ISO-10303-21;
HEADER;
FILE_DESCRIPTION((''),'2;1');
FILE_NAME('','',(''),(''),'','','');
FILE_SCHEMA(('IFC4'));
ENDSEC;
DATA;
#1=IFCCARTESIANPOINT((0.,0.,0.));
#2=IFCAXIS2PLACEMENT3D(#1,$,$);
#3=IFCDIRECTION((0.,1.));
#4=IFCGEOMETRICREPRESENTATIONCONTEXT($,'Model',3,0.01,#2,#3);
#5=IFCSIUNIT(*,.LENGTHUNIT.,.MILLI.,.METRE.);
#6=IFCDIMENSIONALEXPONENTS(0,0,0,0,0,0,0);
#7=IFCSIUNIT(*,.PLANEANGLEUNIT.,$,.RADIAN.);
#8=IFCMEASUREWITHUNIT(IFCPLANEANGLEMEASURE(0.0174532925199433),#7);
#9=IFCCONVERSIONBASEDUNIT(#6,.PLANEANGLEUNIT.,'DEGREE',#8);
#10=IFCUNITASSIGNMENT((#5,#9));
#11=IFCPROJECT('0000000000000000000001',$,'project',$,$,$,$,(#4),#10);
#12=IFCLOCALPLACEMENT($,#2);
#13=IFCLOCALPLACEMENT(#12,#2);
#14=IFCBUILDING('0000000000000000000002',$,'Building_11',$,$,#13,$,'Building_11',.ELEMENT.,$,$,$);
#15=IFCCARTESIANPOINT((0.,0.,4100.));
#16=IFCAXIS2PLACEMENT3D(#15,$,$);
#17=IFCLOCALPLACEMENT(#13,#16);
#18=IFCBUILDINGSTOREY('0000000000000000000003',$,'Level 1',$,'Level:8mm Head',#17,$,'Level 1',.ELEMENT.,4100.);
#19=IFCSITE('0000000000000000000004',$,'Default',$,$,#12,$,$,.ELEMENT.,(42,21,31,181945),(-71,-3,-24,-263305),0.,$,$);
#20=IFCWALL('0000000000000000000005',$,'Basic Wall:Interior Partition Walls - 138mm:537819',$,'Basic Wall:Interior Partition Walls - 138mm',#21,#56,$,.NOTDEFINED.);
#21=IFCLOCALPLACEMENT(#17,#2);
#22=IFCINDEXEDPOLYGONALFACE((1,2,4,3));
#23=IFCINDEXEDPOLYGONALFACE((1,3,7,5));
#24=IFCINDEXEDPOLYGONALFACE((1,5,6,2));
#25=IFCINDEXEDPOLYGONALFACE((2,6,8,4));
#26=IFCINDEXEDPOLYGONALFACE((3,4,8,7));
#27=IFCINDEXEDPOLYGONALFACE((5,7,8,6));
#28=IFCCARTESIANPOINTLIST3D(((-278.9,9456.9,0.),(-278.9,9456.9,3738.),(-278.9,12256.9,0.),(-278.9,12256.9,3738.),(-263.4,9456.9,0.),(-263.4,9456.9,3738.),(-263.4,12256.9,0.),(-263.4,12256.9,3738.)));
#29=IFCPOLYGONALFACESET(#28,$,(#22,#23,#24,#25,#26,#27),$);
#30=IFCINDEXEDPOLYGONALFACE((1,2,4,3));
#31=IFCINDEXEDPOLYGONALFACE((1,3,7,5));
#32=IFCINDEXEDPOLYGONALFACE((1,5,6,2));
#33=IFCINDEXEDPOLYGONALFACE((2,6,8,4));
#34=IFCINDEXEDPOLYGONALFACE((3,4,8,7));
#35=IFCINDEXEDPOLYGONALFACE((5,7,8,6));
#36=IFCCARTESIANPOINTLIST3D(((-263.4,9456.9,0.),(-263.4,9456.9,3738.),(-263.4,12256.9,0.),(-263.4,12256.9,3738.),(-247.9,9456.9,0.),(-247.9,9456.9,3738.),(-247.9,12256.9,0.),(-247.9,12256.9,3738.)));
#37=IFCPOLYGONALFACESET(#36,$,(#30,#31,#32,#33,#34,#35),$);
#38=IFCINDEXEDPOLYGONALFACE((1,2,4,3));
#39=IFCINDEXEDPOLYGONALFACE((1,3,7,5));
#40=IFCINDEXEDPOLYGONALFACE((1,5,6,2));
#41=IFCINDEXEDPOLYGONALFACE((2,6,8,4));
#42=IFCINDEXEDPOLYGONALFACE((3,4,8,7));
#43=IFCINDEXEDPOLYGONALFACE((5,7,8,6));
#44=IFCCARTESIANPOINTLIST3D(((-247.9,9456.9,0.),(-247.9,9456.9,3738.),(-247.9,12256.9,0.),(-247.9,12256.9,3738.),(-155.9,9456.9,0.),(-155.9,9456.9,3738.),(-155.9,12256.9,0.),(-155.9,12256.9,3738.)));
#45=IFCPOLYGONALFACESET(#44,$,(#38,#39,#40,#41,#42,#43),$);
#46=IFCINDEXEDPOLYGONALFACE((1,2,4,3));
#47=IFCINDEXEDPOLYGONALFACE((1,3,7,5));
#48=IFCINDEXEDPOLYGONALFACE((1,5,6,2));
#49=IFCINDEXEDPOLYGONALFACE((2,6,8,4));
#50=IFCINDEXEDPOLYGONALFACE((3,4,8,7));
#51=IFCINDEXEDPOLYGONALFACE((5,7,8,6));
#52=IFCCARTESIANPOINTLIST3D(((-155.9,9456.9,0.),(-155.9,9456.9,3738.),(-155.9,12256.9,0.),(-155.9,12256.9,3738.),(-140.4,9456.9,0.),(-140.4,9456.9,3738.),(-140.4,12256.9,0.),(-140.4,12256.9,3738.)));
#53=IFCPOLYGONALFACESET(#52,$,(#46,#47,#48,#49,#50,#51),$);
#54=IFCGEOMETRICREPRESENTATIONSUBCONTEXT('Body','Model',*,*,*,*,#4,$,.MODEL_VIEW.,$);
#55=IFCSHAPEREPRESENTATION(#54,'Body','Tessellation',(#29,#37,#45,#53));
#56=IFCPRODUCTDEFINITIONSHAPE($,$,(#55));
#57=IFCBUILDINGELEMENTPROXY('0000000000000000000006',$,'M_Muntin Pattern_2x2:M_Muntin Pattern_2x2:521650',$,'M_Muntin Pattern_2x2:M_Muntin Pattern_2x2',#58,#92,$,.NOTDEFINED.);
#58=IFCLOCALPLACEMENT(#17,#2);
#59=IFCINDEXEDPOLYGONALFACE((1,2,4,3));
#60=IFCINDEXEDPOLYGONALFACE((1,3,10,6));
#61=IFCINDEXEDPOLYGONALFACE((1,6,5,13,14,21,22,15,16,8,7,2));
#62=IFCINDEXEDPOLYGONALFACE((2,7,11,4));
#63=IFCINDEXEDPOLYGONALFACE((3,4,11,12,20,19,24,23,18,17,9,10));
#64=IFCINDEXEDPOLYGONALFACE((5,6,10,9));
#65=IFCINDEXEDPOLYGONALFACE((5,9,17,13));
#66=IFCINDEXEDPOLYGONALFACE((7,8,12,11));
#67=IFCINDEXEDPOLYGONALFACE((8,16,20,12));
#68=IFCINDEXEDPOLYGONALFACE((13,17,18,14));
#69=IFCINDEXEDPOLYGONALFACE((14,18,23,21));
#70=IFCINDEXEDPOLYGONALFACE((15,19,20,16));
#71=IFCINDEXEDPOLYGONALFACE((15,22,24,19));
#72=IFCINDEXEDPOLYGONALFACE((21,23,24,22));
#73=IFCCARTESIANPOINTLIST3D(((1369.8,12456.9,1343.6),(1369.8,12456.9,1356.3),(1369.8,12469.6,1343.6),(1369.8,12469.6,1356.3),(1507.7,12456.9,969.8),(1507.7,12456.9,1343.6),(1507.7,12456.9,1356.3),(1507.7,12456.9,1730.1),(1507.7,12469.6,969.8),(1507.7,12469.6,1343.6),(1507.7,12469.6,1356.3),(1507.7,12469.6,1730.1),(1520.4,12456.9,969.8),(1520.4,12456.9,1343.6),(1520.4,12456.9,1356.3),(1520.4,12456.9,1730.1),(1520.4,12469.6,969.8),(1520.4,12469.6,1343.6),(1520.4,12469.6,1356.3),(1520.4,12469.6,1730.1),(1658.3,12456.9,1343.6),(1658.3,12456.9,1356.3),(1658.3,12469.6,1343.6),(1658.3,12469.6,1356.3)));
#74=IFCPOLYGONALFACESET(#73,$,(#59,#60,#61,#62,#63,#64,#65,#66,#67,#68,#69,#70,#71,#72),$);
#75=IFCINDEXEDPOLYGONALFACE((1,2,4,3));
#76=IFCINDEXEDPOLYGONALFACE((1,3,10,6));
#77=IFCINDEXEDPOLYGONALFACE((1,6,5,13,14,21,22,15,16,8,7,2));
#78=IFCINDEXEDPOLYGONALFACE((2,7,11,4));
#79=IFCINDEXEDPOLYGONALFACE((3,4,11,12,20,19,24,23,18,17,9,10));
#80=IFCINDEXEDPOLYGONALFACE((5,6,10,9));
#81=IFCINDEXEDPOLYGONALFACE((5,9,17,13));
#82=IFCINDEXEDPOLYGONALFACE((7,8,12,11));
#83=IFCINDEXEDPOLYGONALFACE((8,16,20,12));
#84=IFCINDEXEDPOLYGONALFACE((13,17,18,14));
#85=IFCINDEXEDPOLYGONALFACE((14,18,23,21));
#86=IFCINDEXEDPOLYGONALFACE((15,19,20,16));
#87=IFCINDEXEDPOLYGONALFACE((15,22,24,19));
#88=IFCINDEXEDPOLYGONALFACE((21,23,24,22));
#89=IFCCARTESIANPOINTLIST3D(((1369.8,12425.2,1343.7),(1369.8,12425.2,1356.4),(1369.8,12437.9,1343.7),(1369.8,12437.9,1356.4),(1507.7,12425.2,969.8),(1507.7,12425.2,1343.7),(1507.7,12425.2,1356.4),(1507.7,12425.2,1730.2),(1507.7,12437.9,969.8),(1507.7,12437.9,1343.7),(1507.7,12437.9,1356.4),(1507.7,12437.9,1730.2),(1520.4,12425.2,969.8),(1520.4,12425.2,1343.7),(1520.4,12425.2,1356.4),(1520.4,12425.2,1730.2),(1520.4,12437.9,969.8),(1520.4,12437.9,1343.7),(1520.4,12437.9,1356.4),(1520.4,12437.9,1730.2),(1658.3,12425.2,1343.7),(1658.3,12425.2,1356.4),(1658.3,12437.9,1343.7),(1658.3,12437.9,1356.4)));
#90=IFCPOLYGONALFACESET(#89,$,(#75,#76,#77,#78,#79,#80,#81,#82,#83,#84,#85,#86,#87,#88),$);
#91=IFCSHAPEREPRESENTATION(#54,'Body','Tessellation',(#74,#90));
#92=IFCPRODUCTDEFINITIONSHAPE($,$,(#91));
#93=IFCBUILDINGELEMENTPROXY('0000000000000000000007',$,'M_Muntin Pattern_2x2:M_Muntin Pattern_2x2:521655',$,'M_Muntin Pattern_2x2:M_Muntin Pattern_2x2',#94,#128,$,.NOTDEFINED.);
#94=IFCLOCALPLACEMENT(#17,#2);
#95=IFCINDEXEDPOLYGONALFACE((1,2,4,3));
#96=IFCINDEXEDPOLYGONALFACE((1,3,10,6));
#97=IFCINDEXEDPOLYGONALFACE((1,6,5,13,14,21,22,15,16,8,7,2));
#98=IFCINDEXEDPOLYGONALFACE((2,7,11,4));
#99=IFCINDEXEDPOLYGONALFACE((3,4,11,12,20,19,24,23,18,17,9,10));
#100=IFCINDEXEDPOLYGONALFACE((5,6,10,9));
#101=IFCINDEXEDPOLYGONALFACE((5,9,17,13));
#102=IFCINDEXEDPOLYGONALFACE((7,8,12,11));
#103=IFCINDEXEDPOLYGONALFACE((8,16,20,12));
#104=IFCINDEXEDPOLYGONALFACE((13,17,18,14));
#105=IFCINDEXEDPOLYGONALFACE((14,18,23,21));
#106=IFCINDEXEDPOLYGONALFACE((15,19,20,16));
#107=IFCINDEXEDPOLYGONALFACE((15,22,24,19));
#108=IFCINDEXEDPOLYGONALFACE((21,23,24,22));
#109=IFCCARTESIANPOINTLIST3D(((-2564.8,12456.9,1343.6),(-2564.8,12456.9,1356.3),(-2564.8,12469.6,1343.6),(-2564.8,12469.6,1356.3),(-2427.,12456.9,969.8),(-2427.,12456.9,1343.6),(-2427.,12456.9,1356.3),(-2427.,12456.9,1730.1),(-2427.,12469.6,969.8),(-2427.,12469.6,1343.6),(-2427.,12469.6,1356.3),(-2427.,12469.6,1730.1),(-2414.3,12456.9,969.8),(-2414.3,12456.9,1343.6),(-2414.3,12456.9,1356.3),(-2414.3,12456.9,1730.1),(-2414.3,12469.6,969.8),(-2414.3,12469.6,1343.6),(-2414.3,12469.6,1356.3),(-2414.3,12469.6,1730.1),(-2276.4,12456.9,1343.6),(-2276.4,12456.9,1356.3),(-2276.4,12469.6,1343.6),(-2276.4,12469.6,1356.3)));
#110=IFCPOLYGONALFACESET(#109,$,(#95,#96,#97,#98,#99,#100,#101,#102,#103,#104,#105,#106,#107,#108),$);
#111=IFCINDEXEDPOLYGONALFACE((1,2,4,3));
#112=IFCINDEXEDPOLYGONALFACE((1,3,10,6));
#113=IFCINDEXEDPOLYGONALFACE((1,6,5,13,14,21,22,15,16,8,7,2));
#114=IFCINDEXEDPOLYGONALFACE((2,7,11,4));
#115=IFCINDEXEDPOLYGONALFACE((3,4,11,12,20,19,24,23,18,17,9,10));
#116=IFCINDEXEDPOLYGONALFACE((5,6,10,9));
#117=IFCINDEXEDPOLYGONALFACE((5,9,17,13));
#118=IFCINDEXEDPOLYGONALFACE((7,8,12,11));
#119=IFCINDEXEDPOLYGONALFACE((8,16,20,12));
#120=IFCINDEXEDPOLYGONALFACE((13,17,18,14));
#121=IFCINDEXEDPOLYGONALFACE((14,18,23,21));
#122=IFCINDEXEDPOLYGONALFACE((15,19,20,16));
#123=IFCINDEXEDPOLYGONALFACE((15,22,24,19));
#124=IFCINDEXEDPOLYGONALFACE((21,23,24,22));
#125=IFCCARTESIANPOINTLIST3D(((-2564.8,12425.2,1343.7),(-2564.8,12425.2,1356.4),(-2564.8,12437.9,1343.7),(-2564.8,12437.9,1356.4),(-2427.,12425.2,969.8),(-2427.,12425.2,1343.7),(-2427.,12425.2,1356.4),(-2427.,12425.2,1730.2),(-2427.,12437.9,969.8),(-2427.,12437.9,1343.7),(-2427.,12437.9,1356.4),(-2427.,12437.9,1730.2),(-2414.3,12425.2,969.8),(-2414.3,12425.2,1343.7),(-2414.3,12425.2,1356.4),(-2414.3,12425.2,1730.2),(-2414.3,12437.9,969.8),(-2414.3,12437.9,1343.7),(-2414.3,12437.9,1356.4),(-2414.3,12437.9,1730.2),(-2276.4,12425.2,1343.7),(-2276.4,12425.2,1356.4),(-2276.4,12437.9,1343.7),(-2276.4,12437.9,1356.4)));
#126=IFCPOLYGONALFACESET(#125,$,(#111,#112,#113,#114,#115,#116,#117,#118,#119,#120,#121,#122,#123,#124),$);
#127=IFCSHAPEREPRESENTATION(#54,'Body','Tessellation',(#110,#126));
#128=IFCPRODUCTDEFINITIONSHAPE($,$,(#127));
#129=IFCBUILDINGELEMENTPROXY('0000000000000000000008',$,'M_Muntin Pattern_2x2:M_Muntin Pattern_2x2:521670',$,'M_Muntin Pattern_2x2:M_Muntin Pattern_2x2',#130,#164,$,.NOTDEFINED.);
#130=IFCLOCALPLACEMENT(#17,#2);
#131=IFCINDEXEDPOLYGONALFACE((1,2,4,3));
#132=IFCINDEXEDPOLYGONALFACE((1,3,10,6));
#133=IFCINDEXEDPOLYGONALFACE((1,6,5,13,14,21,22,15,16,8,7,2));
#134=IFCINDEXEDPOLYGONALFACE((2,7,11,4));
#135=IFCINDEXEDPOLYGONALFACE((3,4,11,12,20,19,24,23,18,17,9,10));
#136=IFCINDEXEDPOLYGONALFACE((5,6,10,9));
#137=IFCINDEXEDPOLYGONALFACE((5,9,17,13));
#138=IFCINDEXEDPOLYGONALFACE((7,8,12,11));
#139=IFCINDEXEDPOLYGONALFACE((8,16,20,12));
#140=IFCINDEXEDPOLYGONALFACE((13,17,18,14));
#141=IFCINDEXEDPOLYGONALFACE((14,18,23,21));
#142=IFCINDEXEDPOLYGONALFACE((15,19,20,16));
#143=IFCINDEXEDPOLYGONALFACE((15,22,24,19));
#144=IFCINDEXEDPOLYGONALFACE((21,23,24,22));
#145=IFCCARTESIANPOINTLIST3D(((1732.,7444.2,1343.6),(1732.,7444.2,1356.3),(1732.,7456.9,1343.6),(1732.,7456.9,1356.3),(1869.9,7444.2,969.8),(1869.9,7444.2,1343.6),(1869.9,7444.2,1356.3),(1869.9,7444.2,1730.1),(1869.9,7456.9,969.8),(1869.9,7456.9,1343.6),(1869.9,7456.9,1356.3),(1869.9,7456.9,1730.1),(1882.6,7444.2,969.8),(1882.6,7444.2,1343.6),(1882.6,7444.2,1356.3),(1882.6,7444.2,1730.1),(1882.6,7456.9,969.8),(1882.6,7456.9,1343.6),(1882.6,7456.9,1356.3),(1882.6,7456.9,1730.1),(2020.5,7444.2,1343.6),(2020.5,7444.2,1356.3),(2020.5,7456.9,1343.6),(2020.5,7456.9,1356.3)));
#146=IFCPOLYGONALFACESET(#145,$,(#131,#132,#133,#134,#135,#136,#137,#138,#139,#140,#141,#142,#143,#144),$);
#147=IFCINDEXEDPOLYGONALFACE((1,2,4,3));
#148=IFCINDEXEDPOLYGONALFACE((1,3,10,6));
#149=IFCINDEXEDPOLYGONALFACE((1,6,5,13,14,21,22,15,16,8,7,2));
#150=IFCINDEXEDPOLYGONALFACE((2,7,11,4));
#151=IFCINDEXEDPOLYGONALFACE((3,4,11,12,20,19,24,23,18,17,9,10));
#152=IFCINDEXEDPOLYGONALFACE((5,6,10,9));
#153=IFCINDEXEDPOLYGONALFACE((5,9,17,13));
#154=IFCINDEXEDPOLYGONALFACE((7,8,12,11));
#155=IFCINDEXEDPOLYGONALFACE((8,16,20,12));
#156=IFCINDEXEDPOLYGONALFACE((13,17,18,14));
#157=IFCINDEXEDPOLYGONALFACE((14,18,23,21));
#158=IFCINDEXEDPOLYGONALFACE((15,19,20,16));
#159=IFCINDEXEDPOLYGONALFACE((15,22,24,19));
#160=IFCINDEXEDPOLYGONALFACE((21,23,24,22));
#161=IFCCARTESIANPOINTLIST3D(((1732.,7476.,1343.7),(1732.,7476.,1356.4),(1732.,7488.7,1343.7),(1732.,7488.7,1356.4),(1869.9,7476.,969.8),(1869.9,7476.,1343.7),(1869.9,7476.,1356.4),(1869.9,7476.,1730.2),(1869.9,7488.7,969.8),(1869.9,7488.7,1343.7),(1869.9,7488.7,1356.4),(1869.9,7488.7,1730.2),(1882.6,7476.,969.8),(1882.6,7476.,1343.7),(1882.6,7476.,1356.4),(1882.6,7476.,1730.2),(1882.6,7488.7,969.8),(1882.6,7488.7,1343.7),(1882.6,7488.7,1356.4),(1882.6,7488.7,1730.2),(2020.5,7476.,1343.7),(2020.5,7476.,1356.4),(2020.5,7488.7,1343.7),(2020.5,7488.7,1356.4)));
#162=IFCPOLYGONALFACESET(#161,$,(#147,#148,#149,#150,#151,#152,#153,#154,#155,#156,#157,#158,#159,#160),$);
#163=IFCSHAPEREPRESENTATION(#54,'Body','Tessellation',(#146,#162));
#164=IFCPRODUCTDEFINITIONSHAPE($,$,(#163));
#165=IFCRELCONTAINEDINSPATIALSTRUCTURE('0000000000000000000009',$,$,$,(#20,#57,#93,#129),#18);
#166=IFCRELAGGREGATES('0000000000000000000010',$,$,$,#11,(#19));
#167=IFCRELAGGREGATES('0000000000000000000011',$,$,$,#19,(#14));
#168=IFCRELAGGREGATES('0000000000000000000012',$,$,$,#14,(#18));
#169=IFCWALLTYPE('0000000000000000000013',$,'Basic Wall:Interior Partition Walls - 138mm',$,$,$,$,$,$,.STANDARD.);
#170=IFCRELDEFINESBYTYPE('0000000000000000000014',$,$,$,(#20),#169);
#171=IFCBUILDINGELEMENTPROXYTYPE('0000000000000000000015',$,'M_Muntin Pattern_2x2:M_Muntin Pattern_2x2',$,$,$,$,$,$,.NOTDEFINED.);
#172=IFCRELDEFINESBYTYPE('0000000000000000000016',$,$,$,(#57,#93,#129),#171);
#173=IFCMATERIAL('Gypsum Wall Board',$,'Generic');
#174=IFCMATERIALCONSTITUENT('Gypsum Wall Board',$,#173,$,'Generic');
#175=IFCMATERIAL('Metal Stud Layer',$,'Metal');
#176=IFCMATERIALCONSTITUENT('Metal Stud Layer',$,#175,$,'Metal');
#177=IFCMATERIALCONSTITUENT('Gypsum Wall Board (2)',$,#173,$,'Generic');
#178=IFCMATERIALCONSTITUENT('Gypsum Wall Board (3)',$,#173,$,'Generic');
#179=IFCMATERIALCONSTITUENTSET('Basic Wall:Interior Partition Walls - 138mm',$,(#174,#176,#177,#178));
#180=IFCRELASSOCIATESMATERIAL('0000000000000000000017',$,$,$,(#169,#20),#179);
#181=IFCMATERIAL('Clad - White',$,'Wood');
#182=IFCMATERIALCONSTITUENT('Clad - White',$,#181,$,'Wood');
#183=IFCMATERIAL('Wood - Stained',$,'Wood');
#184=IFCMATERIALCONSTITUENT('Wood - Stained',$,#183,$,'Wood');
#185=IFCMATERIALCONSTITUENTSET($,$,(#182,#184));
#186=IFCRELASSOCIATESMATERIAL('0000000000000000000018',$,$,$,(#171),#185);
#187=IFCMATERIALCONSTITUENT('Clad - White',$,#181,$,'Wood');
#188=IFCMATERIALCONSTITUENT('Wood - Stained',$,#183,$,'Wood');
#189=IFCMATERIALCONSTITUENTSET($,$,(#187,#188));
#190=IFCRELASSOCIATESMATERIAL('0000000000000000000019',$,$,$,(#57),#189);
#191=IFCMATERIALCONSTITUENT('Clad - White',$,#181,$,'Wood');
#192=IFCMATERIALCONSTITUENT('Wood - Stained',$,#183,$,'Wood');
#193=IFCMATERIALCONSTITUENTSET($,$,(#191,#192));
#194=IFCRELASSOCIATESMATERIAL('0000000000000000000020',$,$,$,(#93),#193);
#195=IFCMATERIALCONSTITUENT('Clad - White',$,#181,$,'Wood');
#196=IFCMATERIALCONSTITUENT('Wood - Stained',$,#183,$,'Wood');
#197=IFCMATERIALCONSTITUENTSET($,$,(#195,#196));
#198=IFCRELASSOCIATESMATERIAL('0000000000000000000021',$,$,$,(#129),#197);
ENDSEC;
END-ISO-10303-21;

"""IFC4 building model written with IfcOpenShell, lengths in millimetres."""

from ifc_helpers import new_model, entity, si_unit, converted_unit, direction, frame, origin, place, context, subcontext, project, spatial, indexed_curve, outline, extrude, source, transform, mapped, material, constituent, constituent_set, type_object, type_shapes, element, save


model = new_model("IFC4")

# Units and contexts
model_context = context("Model", 3, precision=0.01, world=origin(), true_north=direction((0.0, 1.0)))
body_context = subcontext(model_context, "Body", "Model", "MODEL_VIEW")
ifc_project = project(units=[si_unit("LENGTHUNIT", "METRE", prefix="MILLI"), converted_unit("PLANEANGLEUNIT", "DEGREE", entity("IfcPlaneAngleMeasure", 0.0174532925199433), si_unit("PLANEANGLEUNIT", "RADIAN"), dimensions=[0, 0, 0, 0, 0, 0, 0])], contexts=[model_context])

# Site, building, storey
site_placement = place(None, origin())
site = spatial("IfcSite", under=ifc_project, at=site_placement, Name="Default", CompositionType="ELEMENT", RefLatitude=(42, 21, 31, 181945), RefLongitude=(-71, -3, -24, -263305), RefElevation=0.0)
building_placement = place(site_placement, origin())
building = spatial("IfcBuilding", under=site, at=building_placement, Name="Building_11", LongName="Building_11", CompositionType="ELEMENT")
storey_placement = place(building_placement, frame((0.0, 0.0, 4100.0)))
storey = spatial("IfcBuildingStorey", under=building, at=storey_placement, Name="Level 1", ObjectType="Level:8mm Head", LongName="Level 1", CompositionType="ELEMENT", Elevation=4100.0)

# Wall
ifc_material_1 = material(Name="Gypsum Wall Board", Category="Generic")
ifc_constituent_1 = constituent(ifc_material_1, Name="Gypsum Wall Board", Category="Generic")
ifc_material_2 = material(Name="Metal Stud Layer", Category="Metal")
ifc_constituent_2 = constituent(ifc_material_2, Name="Metal Stud Layer", Category="Metal")
ifc_constituent_3 = constituent(ifc_material_1, Name="Gypsum Wall Board (2)", Category="Generic")
ifc_constituent_4 = constituent(ifc_material_1, Name="Gypsum Wall Board (3)", Category="Generic")
ifc_constituent_set_1 = constituent_set(constituents=[ifc_constituent_1, ifc_constituent_2, ifc_constituent_3, ifc_constituent_4], Name="Basic Wall:Interior Partition Walls - 138mm")
wall_type = type_object("IfcWallType", Name="Basic Wall:Interior Partition Walls - 138mm", PredefinedType="STANDARD", material=ifc_constituent_set_1)
wall_placement = place(storey_placement, frame((-209.7, 12256.9, 0.0), z_axis=(0.0, 0.0, 1.0), x_axis=(0.0, -1.0, 0.0)))
element("IfcWall", 1, at=wall_placement, inside=storey, type_object=wall_type, material=ifc_constituent_set_1, Name="Basic Wall:Interior Partition Walls - 138mm:537819", ObjectType="Basic Wall:Interior Partition Walls - 138mm", PredefinedType="NOTDEFINED", context=body_context, shape_type="SweptSolid", body=[
    extrude(outline(indexed_curve([(-1869.0, -1400.0), (1869.0, -1400.0), (1869.0, 1400.0), (-1869.0, 1400.0), (-1869.0, -1400.0)], self_intersect=False)), frame((1400.0, -69.2, 1869.0), z_axis=(0.0, 1.0, 0.0), x_axis=(0.0, 0.0, 1.0)), (0.0, 0.0, 1.0), 15.5),
    extrude(outline(indexed_curve([(-1869.0, -1400.0), (1869.0, -1400.0), (1869.0, 1400.0), (-1869.0, 1400.0), (-1869.0, -1400.0)], self_intersect=False)), frame((1400.0, -53.8, 1869.0), z_axis=(0.0, 1.0, 0.0), x_axis=(0.0, 0.0, 1.0)), (0.0, 0.0, 1.0), 15.5),
    extrude(outline(indexed_curve([(-1869.0, -1400.0), (1869.0, -1400.0), (1869.0, 1400.0), (-1869.0, 1400.0), (-1869.0, -1400.0)], self_intersect=False)), frame((1400.0, -38.2, 1869.0), z_axis=(0.0, 1.0, 0.0), x_axis=(0.0, 0.0, 1.0)), (0.0, 0.0, 1.0), 92.0),
    extrude(outline(indexed_curve([(-1869.0, -1400.0), (1869.0, -1400.0), (1869.0, 1400.0), (-1869.0, 1400.0), (-1869.0, -1400.0)], self_intersect=False)), frame((1400.0, 53.7, 1869.0), z_axis=(0.0, 1.0, 0.0), x_axis=(0.0, 0.0, 1.0)), (0.0, 0.0, 1.0), 15.5),
])

# Building element proxies
ifc_material_3 = material(Name="Clad - White", Category="Wood")
ifc_constituent_5 = constituent(ifc_material_3, Name="Clad - White", Category="Wood")
ifc_material_4 = material(Name="Wood - Stained", Category="Wood")
ifc_constituent_6 = constituent(ifc_material_4, Name="Wood - Stained", Category="Wood")
ifc_constituent_set_2 = constituent_set(constituents=[ifc_constituent_5, ifc_constituent_6])
ifc_constituent_7 = constituent(ifc_material_3, Name="Clad - White", Category="Wood")
ifc_constituent_8 = constituent(ifc_material_4, Name="Wood - Stained", Category="Wood")
ifc_constituent_set_3 = constituent_set(constituents=[ifc_constituent_7, ifc_constituent_8])
building_element_proxy_type_1 = type_object("IfcBuildingElementProxyType", Name="M_Muntin Pattern_2x2:M_Muntin Pattern_2x2", PredefinedType="NOTDEFINED", material=ifc_constituent_set_3)
shared_shape_1 = source(origin(), body_context, "Body", "SweptSolid", [
    extrude(outline(indexed_curve([(6.4, -6.4), (380.1, -6.4), (380.1, 6.3), (6.4, 6.3), (6.4, 144.2), (-6.3, 144.2), (-6.3, 6.3), (-380.2, 6.3), (-380.2, -6.4), (-6.3, -6.4), (-6.3, -144.2), (6.4, -144.2), (6.4, -6.4)], self_intersect=False)), frame((0.0, 9.5, 380.1), z_axis=(0.0, 1.0, 0.0), x_axis=(0.0, 0.0, 1.0)), (0.0, 0.0, 1.0), 12.7),
    extrude(outline(indexed_curve([(6.4, -6.4), (380.2, -6.4), (380.2, 6.3), (6.4, 6.3), (6.4, 144.2), (-6.3, 144.2), (-6.3, 6.3), (-380.2, 6.3), (-380.2, -6.4), (-6.3, -6.4), (-6.3, -144.2), (6.4, -144.2), (6.4, -6.4)], self_intersect=False)), frame((0.0, -22.2, 380.2), z_axis=(0.0, 1.0, 0.0), x_axis=(0.0, 0.0, 1.0)), (0.0, 0.0, 1.0), 12.7),
])
type_shapes(building_element_proxy_type_1, [shared_shape_1])
proxy_1_placement = place(storey_placement, frame((1514.0, 12447.4, 969.8)))
element("IfcBuildingElementProxy", 2, at=proxy_1_placement, inside=storey, type_object=building_element_proxy_type_1, material=ifc_constituent_set_2, Name="M_Muntin Pattern_2x2:M_Muntin Pattern_2x2:521650", ObjectType="M_Muntin Pattern_2x2:M_Muntin Pattern_2x2", PredefinedType="NOTDEFINED", context=body_context, shape_type="MappedRepresentation", body=[
    mapped(shared_shape_1, transform((0.0, 0.0, 0.0), scale=1.0)),
])
ifc_constituent_9 = constituent(ifc_material_3, Name="Clad - White", Category="Wood")
ifc_constituent_10 = constituent(ifc_material_4, Name="Wood - Stained", Category="Wood")
ifc_constituent_set_4 = constituent_set(constituents=[ifc_constituent_9, ifc_constituent_10])
proxy_2_placement = place(storey_placement, frame((-2420.6, 12447.4, 969.8)))
element("IfcBuildingElementProxy", 3, at=proxy_2_placement, inside=storey, type_object=building_element_proxy_type_1, material=ifc_constituent_set_4, Name="M_Muntin Pattern_2x2:M_Muntin Pattern_2x2:521655", ObjectType="M_Muntin Pattern_2x2:M_Muntin Pattern_2x2", PredefinedType="NOTDEFINED", context=body_context, shape_type="MappedRepresentation", body=[
    mapped(shared_shape_1, transform((0.0, 0.0, 0.0), scale=1.0)),
])
ifc_constituent_11 = constituent(ifc_material_3, Name="Clad - White", Category="Wood")
ifc_constituent_12 = constituent(ifc_material_4, Name="Wood - Stained", Category="Wood")
ifc_constituent_set_5 = constituent_set(constituents=[ifc_constituent_11, ifc_constituent_12])
proxy_3_placement = place(storey_placement, frame((1876.2, 7466.4, 969.8), z_axis=(0.0, 0.0, 1.0), x_axis=(-1.0, 0.0, 0.0)))
element("IfcBuildingElementProxy", 4, at=proxy_3_placement, inside=storey, type_object=building_element_proxy_type_1, material=ifc_constituent_set_5, Name="M_Muntin Pattern_2x2:M_Muntin Pattern_2x2:521670", ObjectType="M_Muntin Pattern_2x2:M_Muntin Pattern_2x2", PredefinedType="NOTDEFINED", context=body_context, shape_type="MappedRepresentation", body=[
    mapped(shared_shape_1, transform((0.0, 0.0, 0.0), scale=1.0)),
])

save(model, "model.ifc")
